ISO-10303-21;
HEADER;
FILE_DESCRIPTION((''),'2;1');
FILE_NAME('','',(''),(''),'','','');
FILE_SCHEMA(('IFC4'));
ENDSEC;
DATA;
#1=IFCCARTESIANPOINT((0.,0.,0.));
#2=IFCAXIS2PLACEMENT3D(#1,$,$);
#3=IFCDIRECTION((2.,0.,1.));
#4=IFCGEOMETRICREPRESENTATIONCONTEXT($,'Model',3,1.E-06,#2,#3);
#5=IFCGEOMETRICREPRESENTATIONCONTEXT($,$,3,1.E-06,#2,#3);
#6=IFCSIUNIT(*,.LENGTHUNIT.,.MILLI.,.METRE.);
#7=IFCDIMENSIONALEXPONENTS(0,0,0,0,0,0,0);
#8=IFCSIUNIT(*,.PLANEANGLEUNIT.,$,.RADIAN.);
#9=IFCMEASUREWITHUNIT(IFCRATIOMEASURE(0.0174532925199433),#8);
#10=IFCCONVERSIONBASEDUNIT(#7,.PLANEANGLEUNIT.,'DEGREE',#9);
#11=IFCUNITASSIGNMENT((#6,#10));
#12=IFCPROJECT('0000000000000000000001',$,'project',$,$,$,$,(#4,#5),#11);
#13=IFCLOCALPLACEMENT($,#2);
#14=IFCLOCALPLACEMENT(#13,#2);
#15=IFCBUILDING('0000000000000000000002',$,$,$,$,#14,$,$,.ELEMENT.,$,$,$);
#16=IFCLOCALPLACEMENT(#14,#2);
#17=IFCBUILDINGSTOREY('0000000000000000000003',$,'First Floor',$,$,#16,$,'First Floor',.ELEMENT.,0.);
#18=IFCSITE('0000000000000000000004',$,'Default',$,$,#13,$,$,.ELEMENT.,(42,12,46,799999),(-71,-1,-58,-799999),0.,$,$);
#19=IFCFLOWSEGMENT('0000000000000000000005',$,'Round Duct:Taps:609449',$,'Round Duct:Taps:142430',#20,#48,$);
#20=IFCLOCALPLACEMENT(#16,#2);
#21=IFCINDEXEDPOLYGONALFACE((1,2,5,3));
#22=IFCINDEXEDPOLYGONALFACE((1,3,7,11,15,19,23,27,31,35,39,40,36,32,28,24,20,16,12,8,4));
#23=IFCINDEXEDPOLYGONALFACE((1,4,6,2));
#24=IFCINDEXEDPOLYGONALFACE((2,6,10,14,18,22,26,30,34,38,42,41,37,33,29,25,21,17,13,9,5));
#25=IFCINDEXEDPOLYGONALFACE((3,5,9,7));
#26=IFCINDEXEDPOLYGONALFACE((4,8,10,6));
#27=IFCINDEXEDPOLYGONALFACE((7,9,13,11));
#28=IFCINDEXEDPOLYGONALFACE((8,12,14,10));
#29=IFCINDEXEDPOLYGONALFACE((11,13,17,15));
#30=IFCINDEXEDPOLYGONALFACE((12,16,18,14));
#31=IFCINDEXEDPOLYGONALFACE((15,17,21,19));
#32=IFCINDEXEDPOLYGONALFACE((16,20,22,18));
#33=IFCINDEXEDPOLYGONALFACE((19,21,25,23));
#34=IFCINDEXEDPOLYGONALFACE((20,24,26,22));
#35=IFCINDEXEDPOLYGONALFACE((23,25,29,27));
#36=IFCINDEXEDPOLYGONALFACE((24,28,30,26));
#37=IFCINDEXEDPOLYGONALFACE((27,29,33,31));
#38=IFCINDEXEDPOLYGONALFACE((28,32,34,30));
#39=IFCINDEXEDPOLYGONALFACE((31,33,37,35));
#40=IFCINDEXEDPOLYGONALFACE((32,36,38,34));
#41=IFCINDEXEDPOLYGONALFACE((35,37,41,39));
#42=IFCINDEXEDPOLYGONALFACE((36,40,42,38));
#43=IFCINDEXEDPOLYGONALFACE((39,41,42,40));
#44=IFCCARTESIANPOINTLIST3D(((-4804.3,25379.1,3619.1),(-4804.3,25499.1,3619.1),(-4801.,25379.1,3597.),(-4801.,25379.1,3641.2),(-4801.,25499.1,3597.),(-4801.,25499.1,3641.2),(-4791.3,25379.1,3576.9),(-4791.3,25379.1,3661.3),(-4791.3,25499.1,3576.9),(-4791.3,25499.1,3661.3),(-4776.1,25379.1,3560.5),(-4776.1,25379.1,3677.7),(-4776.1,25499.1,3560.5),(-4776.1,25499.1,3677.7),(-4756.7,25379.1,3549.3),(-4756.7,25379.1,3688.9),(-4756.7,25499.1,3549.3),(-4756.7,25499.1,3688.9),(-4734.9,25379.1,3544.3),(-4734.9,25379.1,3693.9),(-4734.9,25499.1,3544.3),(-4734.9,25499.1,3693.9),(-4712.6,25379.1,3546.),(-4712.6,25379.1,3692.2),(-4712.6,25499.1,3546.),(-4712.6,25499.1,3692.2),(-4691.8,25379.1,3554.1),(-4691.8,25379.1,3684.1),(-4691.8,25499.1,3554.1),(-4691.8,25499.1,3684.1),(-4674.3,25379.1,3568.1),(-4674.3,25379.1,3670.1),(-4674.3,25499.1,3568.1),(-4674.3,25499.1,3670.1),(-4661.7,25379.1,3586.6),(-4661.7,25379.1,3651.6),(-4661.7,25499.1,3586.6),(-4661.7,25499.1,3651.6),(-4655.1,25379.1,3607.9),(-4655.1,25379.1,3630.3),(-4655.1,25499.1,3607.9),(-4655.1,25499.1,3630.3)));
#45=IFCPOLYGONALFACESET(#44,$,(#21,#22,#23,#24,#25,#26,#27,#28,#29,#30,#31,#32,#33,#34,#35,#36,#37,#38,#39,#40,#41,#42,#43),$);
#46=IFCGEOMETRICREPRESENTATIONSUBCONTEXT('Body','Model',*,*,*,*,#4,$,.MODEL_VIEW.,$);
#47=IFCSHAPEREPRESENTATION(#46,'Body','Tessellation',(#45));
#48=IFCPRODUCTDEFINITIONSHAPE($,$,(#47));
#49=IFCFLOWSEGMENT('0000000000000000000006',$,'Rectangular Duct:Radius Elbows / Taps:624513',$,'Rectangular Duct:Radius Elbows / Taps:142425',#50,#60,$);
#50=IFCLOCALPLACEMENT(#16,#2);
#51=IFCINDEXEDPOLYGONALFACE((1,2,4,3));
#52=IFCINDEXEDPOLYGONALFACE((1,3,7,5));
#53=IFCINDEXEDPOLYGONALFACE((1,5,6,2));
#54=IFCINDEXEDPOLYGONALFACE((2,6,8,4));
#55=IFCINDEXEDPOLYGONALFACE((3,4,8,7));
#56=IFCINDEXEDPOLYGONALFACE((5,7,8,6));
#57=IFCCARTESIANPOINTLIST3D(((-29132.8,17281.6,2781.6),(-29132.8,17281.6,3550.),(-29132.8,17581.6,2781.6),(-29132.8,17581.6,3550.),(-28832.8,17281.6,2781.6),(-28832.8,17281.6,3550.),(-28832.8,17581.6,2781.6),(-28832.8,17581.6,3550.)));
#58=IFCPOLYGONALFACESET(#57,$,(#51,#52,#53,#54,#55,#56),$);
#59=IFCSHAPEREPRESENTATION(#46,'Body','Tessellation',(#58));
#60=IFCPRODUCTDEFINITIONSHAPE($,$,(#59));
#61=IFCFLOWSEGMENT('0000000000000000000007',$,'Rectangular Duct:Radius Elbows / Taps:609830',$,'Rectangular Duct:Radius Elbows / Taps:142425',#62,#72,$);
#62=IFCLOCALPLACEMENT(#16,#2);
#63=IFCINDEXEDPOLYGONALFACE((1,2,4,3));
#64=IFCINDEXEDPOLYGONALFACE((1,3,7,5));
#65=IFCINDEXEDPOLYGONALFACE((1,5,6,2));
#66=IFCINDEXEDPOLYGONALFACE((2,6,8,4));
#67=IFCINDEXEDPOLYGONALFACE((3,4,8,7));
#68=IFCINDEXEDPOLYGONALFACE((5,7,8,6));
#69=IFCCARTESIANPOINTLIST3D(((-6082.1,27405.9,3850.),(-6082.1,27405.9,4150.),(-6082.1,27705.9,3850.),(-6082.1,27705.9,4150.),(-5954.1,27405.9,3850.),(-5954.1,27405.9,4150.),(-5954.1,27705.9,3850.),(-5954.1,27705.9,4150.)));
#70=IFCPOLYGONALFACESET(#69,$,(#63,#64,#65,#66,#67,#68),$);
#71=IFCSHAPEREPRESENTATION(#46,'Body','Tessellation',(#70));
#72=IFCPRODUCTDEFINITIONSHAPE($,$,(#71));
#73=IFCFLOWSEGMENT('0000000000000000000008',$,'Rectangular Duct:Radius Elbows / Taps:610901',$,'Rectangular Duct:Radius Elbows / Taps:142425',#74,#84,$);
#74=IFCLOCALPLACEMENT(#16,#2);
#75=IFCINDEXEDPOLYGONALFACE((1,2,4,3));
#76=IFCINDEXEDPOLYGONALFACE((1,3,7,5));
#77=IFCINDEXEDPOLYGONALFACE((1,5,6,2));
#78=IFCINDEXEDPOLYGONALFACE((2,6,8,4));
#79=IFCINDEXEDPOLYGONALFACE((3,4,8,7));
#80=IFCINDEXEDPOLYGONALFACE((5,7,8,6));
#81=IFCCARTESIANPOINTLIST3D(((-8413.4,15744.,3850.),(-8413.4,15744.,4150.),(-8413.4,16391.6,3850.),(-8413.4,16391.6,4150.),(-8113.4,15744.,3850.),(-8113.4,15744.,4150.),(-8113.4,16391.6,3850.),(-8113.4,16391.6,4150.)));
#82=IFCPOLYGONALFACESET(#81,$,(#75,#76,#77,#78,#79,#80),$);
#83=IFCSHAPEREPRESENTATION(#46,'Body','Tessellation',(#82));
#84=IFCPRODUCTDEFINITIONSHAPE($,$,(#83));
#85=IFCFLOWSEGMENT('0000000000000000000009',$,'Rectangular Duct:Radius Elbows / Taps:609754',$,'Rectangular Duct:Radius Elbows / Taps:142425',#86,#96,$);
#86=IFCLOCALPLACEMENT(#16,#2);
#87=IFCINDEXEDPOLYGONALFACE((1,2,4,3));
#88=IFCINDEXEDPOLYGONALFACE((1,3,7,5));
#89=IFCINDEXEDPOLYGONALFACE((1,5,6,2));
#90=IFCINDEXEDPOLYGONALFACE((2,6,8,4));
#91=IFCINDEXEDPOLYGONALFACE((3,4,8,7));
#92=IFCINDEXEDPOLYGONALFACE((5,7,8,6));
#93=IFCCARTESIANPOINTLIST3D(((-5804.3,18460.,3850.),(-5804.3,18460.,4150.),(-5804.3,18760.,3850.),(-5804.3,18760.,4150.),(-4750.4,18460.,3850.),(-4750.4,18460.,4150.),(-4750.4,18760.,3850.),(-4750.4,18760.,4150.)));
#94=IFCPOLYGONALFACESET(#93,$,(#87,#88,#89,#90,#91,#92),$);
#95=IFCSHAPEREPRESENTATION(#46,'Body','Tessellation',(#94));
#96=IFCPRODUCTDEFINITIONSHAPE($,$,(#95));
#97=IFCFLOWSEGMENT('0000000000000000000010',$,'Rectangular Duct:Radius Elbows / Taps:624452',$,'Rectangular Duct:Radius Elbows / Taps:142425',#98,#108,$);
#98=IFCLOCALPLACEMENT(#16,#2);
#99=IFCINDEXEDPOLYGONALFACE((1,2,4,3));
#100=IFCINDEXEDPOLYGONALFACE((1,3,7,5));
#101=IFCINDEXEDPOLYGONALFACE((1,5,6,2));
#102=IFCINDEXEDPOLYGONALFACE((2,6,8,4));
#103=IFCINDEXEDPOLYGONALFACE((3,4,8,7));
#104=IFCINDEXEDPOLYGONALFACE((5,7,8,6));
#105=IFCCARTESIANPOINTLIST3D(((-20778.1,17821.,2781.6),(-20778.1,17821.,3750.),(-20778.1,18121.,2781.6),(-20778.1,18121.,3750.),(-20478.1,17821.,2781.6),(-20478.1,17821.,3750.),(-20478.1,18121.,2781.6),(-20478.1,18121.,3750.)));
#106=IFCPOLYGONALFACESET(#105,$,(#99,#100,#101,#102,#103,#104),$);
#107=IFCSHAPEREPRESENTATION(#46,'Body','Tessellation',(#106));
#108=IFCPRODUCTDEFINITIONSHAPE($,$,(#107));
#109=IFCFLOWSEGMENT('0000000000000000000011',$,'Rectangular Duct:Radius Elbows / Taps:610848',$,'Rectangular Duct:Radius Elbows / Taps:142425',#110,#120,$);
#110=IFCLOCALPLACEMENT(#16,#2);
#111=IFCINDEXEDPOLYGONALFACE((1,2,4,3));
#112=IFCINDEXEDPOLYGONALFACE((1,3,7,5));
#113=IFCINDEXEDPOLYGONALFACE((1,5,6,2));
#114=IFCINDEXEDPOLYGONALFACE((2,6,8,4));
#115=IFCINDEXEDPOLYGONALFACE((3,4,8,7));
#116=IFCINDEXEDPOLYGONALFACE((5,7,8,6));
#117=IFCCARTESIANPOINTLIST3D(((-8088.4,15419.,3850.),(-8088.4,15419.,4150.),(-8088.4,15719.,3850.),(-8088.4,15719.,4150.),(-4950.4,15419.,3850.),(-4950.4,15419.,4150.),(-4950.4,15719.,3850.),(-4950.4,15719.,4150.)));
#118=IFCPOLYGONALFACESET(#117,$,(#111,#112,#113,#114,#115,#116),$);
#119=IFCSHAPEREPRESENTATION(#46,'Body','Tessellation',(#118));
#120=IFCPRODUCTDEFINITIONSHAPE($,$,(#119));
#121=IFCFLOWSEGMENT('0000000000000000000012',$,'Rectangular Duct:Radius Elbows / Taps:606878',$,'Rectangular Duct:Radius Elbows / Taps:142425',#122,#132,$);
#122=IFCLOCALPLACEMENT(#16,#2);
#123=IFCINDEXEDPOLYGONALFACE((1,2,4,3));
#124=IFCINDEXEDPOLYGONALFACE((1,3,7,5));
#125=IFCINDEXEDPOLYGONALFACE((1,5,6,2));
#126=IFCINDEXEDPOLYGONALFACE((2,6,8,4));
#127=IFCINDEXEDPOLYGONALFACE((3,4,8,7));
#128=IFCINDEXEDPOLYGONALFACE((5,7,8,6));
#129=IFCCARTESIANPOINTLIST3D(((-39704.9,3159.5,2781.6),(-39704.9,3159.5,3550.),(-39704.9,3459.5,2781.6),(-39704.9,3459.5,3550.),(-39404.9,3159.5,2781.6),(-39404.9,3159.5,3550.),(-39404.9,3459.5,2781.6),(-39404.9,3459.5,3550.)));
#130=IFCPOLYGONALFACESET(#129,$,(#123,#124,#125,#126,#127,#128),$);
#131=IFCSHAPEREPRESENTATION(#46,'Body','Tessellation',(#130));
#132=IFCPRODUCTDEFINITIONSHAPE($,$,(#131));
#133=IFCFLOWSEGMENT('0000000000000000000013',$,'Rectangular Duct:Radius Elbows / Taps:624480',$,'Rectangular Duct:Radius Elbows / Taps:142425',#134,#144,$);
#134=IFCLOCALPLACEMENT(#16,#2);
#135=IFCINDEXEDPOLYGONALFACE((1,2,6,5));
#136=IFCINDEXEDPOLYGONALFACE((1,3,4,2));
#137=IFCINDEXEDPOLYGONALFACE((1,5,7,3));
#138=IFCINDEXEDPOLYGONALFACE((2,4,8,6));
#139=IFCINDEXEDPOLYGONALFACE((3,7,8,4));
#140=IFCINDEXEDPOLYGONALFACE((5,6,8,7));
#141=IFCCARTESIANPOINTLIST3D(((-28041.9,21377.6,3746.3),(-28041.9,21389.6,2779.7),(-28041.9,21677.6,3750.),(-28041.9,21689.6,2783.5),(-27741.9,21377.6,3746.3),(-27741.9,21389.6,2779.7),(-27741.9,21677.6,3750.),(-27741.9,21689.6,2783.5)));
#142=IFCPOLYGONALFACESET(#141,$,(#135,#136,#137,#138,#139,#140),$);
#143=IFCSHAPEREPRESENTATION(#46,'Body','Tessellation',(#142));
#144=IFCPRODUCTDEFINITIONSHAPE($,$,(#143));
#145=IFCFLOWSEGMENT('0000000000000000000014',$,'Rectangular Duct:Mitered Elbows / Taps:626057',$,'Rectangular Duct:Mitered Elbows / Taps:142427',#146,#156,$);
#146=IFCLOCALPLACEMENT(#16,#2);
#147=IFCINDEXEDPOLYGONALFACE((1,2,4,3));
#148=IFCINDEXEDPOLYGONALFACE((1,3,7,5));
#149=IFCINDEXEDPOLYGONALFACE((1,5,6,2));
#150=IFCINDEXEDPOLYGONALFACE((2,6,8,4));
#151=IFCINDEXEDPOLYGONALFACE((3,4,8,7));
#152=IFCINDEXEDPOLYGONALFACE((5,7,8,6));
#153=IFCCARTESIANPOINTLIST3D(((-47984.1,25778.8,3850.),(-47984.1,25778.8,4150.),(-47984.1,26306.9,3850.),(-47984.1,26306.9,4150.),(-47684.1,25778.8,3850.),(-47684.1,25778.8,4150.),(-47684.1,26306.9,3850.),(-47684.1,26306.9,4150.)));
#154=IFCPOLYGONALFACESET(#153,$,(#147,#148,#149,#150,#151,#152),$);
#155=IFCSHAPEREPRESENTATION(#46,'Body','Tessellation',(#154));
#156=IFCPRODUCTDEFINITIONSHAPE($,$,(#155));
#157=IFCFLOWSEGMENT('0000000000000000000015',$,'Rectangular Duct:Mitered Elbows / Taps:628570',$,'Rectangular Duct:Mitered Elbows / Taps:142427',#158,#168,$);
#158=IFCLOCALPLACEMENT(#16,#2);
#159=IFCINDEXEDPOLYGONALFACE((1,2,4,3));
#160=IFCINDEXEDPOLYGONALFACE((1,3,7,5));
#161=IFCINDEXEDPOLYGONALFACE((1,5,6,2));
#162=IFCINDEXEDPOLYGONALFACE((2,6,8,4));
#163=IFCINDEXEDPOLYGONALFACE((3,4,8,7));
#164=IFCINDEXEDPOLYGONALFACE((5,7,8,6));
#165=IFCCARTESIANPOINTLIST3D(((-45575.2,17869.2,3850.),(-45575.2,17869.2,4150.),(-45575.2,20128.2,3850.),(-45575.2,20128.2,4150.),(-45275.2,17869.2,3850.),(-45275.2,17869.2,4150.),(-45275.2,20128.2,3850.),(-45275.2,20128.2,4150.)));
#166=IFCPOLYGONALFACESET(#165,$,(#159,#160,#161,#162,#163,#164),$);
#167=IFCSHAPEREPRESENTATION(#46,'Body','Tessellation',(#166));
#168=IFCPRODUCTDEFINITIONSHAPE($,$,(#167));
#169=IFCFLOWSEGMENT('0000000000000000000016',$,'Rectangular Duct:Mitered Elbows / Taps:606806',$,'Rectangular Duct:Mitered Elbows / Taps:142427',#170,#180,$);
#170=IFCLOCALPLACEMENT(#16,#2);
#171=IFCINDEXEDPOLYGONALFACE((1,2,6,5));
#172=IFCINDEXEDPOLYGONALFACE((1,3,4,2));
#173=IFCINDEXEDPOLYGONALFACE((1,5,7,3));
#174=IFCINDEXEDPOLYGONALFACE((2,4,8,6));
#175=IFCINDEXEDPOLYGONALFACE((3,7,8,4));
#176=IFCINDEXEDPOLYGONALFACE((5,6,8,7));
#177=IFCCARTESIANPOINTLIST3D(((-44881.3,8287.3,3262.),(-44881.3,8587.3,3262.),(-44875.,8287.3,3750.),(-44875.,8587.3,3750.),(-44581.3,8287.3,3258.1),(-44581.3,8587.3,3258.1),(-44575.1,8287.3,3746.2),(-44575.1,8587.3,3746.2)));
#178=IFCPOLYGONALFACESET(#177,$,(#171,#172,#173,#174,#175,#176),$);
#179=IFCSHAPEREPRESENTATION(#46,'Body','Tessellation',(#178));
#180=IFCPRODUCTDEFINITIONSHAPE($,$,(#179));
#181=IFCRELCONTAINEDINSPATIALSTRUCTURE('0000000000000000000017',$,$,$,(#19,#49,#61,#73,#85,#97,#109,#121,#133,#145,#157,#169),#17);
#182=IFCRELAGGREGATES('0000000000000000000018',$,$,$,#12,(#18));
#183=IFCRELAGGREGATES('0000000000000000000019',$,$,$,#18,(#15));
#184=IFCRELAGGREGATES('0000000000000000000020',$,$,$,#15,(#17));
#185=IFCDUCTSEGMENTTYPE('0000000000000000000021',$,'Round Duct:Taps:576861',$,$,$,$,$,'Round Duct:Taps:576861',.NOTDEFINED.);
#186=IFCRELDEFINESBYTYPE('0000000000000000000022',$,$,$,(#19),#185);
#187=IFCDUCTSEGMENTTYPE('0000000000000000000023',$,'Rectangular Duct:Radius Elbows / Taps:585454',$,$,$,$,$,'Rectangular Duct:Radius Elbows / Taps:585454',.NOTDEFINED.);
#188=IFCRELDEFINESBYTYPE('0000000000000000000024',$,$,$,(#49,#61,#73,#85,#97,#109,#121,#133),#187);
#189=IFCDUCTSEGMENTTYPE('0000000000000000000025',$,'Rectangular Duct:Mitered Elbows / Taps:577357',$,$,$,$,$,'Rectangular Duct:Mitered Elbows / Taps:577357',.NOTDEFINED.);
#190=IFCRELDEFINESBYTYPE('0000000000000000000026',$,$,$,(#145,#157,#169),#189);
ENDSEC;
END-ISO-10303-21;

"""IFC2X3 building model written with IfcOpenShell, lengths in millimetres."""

from ifc_helpers import new_model, entity, si_unit, converted_unit, direction, frame, frame_2d, origin, origin_2d_with_axis, place, context, subcontext, project, spatial, rectangle, circle, extrude, type_object, element, save


model = new_model("IFC2X3")

# Units and contexts
model_context = context("Model", 3, precision=1e-06, world=origin(), true_north=direction((2.0, 0.0, 1.0)))
context_of_model = context(None, 3, precision=1e-06, world=origin(), true_north=direction((2.0, 0.0, 1.0)))
body_context = subcontext(model_context, "Body", "Model", "MODEL_VIEW")
ifc_project = project(units=[si_unit("LENGTHUNIT", "METRE", prefix="MILLI"), converted_unit("PLANEANGLEUNIT", "DEGREE", entity("IfcRatioMeasure", 0.0174532925199433), si_unit("PLANEANGLEUNIT", "RADIAN"), dimensions=[0, 0, 0, 0, 0, 0, 0])], contexts=[model_context, context_of_model])

# Site, building, storey
site_placement = place(None, origin())
site = spatial("IfcSite", under=ifc_project, at=site_placement, Name="Default", CompositionType="ELEMENT", RefLatitude=(42, 12, 46, 799999), RefLongitude=(-71, -1, -58, -799999), RefElevation=0.0)
building_placement = place(site_placement, origin())
building = spatial("IfcBuilding", under=site, at=building_placement, CompositionType="ELEMENT")
storey_placement = place(building_placement, origin())
storey = spatial("IfcBuildingStorey", under=building, at=storey_placement, Name="First Floor", LongName="First Floor", CompositionType="ELEMENT", Elevation=0.0)

# Flow segments
duct_segment_type_1 = type_object("IfcDuctSegmentType", Name="Round Duct:Taps:576861", ElementType="Round Duct:Taps:576861", PredefinedType="NOTDEFINED")
flow_segment_1_placement = place(storey_placement, origin())
element("IfcFlowSegment", 1, at=flow_segment_1_placement, inside=storey, type_object=duct_segment_type_1, Name="Round Duct:Taps:609449", ObjectType="Round Duct:Taps:142430", context=body_context, shape_type="SweptSolid", body=[
    extrude(circle(Radius=75.0, at=frame_2d((0.0, 0.0), x_axis=(1.0, 0.0))), frame((-4729.3, 25379.1, 3619.1), z_axis=(0.0, 1.0, 0.0), x_axis=(-1.0, 0.0, 0.0)), (0.0, 0.0, 1.0), 120.0),
])
duct_segment_type_2 = type_object("IfcDuctSegmentType", Name="Rectangular Duct:Radius Elbows / Taps:585454", ElementType="Rectangular Duct:Radius Elbows / Taps:585454", PredefinedType="NOTDEFINED")
flow_segment_2_placement = place(storey_placement, origin())
element("IfcFlowSegment", 2, at=flow_segment_2_placement, inside=storey, type_object=duct_segment_type_2, Name="Rectangular Duct:Radius Elbows / Taps:624513", ObjectType="Rectangular Duct:Radius Elbows / Taps:142425", context=body_context, shape_type="SweptSolid", body=[
    extrude(rectangle(XDim=300.0, YDim=300.0, at=frame_2d((0.0, 0.0), x_axis=(1.0, 0.0))), frame((-28982.8, 17431.6, 2781.6), z_axis=(0.0, 0.0, 1.0), x_axis=(0.0, -1.0, 0.0)), (0.0, 0.0, 1.0), 768.4),
])
flow_segment_3_placement = place(storey_placement, origin())
element("IfcFlowSegment", 3, at=flow_segment_3_placement, inside=storey, type_object=duct_segment_type_2, Name="Rectangular Duct:Radius Elbows / Taps:609830", ObjectType="Rectangular Duct:Radius Elbows / Taps:142425", context=body_context, shape_type="SweptSolid", body=[
    extrude(rectangle(XDim=128.0, YDim=300.0, at=origin_2d_with_axis()), frame((-6018.1, 27555.9, 3850.0)), (0.0, 0.0, 1.0), 300.0),
])
flow_segment_4_placement = place(storey_placement, origin())
element("IfcFlowSegment", 4, at=flow_segment_4_placement, inside=storey, type_object=duct_segment_type_2, Name="Rectangular Duct:Radius Elbows / Taps:610901", ObjectType="Rectangular Duct:Radius Elbows / Taps:142425", context=body_context, shape_type="SweptSolid", body=[
    extrude(rectangle(XDim=647.5, YDim=300.0, at=frame_2d((0.0, 0.0), x_axis=(1.0, 0.0))), frame((-8263.4, 16067.8, 3850.0), z_axis=(0.0, 0.0, 1.0), x_axis=(0.0, -1.0, 0.0)), (0.0, 0.0, 1.0), 300.0),
])
flow_segment_5_placement = place(storey_placement, origin())
element("IfcFlowSegment", 5, at=flow_segment_5_placement, inside=storey, type_object=duct_segment_type_2, Name="Rectangular Duct:Radius Elbows / Taps:609754", ObjectType="Rectangular Duct:Radius Elbows / Taps:142425", context=body_context, shape_type="SweptSolid", body=[
    extrude(rectangle(XDim=1053.8, YDim=300.0, at=frame_2d((0.0, 0.0), x_axis=(1.0, 0.0))), frame((-5277.4, 18610.0, 3850.0)), (0.0, 0.0, 1.0), 300.0),
])
flow_segment_6_placement = place(storey_placement, origin())
element("IfcFlowSegment", 6, at=flow_segment_6_placement, inside=storey, type_object=duct_segment_type_2, Name="Rectangular Duct:Radius Elbows / Taps:624452", ObjectType="Rectangular Duct:Radius Elbows / Taps:142425", context=body_context, shape_type="SweptSolid", body=[
    extrude(rectangle(XDim=300.0, YDim=300.0, at=origin_2d_with_axis()), frame((-20628.1, 17971.0, 2781.6), z_axis=(0.0, 0.0, 1.0), x_axis=(0.0, 1.0, 0.0)), (0.0, 0.0, 1.0), 968.4),
])
flow_segment_7_placement = place(storey_placement, origin())
element("IfcFlowSegment", 7, at=flow_segment_7_placement, inside=storey, type_object=duct_segment_type_2, Name="Rectangular Duct:Radius Elbows / Taps:610848", ObjectType="Rectangular Duct:Radius Elbows / Taps:142425", context=body_context, shape_type="SweptSolid", body=[
    extrude(rectangle(XDim=3137.9, YDim=300.0, at=frame_2d((0.0, 0.0), x_axis=(1.0, 0.0))), frame((-6519.4, 15569.0, 3850.0), z_axis=(0.0, 0.0, 1.0), x_axis=(-1.0, 0.0, 0.0)), (0.0, 0.0, 1.0), 300.0),
])
flow_segment_8_placement = place(storey_placement, origin())
element("IfcFlowSegment", 8, at=flow_segment_8_placement, inside=storey, type_object=duct_segment_type_2, Name="Rectangular Duct:Radius Elbows / Taps:606878", ObjectType="Rectangular Duct:Radius Elbows / Taps:142425", context=body_context, shape_type="SweptSolid", body=[
    extrude(rectangle(XDim=300.0, YDim=300.0, at=origin_2d_with_axis()), frame((-39554.9, 3309.5, 2781.6), z_axis=(0.0, 0.0, 1.0), x_axis=(-1.0, 0.0, 0.0)), (0.0, 0.0, 1.0), 768.4),
])
flow_segment_9_placement = place(storey_placement, origin())
element("IfcFlowSegment", 9, at=flow_segment_9_placement, inside=storey, type_object=duct_segment_type_2, Name="Rectangular Duct:Radius Elbows / Taps:624480", ObjectType="Rectangular Duct:Radius Elbows / Taps:142425", context=body_context, shape_type="SweptSolid", body=[
    extrude(rectangle(XDim=300.0, YDim=300.0, at=frame_2d((0.0, 0.0), x_axis=(0.0, 1.0))), frame((-27891.9, 21539.6, 2781.6), z_axis=(0.0, -0.012398, 0.999923), x_axis=(1.0, 0.0, 0.0)), (0.0, 0.0, 1.0), 966.6),
])
duct_segment_type_3 = type_object("IfcDuctSegmentType", Name="Rectangular Duct:Mitered Elbows / Taps:577357", ElementType="Rectangular Duct:Mitered Elbows / Taps:577357", PredefinedType="NOTDEFINED")
flow_segment_10_placement = place(storey_placement, origin())
element("IfcFlowSegment", 10, at=flow_segment_10_placement, inside=storey, type_object=duct_segment_type_3, Name="Rectangular Duct:Mitered Elbows / Taps:626057", ObjectType="Rectangular Duct:Mitered Elbows / Taps:142427", context=body_context, shape_type="SweptSolid", body=[
    extrude(rectangle(XDim=528.1, YDim=300.0, at=frame_2d((0.0, 0.0), x_axis=(1.0, 0.0))), frame((-47834.1, 26042.9, 3850.0), z_axis=(0.0, 0.0, 1.0), x_axis=(0.0, 1.0, 0.0)), (0.0, 0.0, 1.0), 300.0),
])
flow_segment_11_placement = place(storey_placement, origin())
element("IfcFlowSegment", 11, at=flow_segment_11_placement, inside=storey, type_object=duct_segment_type_3, Name="Rectangular Duct:Mitered Elbows / Taps:628570", ObjectType="Rectangular Duct:Mitered Elbows / Taps:142427", context=body_context, shape_type="SweptSolid", body=[
    extrude(rectangle(XDim=2259.1, YDim=300.0, at=frame_2d((0.0, 0.0), x_axis=(1.0, 0.0))), frame((-45425.2, 18998.7, 3850.0), z_axis=(0.0, 0.0, 1.0), x_axis=(0.0, 1.0, 0.0)), (0.0, 0.0, 1.0), 300.0),
])
flow_segment_12_placement = place(storey_placement, origin())
element("IfcFlowSegment", 12, at=flow_segment_12_placement, inside=storey, type_object=duct_segment_type_3, Name="Rectangular Duct:Mitered Elbows / Taps:606806", ObjectType="Rectangular Duct:Mitered Elbows / Taps:142427", context=body_context, shape_type="SweptSolid", body=[
    extrude(rectangle(XDim=300.0, YDim=300.0, at=frame_2d((0.0, 0.0), x_axis=(0.0, 1.0))), frame((-44731.3, 8437.3, 3260.1), z_axis=(0.012787, 0.0, 0.999918), x_axis=(0.0, 1.0, 0.0)), (0.0, 0.0, 1.0), 488.1),
])

save(model, "model.ifc")
